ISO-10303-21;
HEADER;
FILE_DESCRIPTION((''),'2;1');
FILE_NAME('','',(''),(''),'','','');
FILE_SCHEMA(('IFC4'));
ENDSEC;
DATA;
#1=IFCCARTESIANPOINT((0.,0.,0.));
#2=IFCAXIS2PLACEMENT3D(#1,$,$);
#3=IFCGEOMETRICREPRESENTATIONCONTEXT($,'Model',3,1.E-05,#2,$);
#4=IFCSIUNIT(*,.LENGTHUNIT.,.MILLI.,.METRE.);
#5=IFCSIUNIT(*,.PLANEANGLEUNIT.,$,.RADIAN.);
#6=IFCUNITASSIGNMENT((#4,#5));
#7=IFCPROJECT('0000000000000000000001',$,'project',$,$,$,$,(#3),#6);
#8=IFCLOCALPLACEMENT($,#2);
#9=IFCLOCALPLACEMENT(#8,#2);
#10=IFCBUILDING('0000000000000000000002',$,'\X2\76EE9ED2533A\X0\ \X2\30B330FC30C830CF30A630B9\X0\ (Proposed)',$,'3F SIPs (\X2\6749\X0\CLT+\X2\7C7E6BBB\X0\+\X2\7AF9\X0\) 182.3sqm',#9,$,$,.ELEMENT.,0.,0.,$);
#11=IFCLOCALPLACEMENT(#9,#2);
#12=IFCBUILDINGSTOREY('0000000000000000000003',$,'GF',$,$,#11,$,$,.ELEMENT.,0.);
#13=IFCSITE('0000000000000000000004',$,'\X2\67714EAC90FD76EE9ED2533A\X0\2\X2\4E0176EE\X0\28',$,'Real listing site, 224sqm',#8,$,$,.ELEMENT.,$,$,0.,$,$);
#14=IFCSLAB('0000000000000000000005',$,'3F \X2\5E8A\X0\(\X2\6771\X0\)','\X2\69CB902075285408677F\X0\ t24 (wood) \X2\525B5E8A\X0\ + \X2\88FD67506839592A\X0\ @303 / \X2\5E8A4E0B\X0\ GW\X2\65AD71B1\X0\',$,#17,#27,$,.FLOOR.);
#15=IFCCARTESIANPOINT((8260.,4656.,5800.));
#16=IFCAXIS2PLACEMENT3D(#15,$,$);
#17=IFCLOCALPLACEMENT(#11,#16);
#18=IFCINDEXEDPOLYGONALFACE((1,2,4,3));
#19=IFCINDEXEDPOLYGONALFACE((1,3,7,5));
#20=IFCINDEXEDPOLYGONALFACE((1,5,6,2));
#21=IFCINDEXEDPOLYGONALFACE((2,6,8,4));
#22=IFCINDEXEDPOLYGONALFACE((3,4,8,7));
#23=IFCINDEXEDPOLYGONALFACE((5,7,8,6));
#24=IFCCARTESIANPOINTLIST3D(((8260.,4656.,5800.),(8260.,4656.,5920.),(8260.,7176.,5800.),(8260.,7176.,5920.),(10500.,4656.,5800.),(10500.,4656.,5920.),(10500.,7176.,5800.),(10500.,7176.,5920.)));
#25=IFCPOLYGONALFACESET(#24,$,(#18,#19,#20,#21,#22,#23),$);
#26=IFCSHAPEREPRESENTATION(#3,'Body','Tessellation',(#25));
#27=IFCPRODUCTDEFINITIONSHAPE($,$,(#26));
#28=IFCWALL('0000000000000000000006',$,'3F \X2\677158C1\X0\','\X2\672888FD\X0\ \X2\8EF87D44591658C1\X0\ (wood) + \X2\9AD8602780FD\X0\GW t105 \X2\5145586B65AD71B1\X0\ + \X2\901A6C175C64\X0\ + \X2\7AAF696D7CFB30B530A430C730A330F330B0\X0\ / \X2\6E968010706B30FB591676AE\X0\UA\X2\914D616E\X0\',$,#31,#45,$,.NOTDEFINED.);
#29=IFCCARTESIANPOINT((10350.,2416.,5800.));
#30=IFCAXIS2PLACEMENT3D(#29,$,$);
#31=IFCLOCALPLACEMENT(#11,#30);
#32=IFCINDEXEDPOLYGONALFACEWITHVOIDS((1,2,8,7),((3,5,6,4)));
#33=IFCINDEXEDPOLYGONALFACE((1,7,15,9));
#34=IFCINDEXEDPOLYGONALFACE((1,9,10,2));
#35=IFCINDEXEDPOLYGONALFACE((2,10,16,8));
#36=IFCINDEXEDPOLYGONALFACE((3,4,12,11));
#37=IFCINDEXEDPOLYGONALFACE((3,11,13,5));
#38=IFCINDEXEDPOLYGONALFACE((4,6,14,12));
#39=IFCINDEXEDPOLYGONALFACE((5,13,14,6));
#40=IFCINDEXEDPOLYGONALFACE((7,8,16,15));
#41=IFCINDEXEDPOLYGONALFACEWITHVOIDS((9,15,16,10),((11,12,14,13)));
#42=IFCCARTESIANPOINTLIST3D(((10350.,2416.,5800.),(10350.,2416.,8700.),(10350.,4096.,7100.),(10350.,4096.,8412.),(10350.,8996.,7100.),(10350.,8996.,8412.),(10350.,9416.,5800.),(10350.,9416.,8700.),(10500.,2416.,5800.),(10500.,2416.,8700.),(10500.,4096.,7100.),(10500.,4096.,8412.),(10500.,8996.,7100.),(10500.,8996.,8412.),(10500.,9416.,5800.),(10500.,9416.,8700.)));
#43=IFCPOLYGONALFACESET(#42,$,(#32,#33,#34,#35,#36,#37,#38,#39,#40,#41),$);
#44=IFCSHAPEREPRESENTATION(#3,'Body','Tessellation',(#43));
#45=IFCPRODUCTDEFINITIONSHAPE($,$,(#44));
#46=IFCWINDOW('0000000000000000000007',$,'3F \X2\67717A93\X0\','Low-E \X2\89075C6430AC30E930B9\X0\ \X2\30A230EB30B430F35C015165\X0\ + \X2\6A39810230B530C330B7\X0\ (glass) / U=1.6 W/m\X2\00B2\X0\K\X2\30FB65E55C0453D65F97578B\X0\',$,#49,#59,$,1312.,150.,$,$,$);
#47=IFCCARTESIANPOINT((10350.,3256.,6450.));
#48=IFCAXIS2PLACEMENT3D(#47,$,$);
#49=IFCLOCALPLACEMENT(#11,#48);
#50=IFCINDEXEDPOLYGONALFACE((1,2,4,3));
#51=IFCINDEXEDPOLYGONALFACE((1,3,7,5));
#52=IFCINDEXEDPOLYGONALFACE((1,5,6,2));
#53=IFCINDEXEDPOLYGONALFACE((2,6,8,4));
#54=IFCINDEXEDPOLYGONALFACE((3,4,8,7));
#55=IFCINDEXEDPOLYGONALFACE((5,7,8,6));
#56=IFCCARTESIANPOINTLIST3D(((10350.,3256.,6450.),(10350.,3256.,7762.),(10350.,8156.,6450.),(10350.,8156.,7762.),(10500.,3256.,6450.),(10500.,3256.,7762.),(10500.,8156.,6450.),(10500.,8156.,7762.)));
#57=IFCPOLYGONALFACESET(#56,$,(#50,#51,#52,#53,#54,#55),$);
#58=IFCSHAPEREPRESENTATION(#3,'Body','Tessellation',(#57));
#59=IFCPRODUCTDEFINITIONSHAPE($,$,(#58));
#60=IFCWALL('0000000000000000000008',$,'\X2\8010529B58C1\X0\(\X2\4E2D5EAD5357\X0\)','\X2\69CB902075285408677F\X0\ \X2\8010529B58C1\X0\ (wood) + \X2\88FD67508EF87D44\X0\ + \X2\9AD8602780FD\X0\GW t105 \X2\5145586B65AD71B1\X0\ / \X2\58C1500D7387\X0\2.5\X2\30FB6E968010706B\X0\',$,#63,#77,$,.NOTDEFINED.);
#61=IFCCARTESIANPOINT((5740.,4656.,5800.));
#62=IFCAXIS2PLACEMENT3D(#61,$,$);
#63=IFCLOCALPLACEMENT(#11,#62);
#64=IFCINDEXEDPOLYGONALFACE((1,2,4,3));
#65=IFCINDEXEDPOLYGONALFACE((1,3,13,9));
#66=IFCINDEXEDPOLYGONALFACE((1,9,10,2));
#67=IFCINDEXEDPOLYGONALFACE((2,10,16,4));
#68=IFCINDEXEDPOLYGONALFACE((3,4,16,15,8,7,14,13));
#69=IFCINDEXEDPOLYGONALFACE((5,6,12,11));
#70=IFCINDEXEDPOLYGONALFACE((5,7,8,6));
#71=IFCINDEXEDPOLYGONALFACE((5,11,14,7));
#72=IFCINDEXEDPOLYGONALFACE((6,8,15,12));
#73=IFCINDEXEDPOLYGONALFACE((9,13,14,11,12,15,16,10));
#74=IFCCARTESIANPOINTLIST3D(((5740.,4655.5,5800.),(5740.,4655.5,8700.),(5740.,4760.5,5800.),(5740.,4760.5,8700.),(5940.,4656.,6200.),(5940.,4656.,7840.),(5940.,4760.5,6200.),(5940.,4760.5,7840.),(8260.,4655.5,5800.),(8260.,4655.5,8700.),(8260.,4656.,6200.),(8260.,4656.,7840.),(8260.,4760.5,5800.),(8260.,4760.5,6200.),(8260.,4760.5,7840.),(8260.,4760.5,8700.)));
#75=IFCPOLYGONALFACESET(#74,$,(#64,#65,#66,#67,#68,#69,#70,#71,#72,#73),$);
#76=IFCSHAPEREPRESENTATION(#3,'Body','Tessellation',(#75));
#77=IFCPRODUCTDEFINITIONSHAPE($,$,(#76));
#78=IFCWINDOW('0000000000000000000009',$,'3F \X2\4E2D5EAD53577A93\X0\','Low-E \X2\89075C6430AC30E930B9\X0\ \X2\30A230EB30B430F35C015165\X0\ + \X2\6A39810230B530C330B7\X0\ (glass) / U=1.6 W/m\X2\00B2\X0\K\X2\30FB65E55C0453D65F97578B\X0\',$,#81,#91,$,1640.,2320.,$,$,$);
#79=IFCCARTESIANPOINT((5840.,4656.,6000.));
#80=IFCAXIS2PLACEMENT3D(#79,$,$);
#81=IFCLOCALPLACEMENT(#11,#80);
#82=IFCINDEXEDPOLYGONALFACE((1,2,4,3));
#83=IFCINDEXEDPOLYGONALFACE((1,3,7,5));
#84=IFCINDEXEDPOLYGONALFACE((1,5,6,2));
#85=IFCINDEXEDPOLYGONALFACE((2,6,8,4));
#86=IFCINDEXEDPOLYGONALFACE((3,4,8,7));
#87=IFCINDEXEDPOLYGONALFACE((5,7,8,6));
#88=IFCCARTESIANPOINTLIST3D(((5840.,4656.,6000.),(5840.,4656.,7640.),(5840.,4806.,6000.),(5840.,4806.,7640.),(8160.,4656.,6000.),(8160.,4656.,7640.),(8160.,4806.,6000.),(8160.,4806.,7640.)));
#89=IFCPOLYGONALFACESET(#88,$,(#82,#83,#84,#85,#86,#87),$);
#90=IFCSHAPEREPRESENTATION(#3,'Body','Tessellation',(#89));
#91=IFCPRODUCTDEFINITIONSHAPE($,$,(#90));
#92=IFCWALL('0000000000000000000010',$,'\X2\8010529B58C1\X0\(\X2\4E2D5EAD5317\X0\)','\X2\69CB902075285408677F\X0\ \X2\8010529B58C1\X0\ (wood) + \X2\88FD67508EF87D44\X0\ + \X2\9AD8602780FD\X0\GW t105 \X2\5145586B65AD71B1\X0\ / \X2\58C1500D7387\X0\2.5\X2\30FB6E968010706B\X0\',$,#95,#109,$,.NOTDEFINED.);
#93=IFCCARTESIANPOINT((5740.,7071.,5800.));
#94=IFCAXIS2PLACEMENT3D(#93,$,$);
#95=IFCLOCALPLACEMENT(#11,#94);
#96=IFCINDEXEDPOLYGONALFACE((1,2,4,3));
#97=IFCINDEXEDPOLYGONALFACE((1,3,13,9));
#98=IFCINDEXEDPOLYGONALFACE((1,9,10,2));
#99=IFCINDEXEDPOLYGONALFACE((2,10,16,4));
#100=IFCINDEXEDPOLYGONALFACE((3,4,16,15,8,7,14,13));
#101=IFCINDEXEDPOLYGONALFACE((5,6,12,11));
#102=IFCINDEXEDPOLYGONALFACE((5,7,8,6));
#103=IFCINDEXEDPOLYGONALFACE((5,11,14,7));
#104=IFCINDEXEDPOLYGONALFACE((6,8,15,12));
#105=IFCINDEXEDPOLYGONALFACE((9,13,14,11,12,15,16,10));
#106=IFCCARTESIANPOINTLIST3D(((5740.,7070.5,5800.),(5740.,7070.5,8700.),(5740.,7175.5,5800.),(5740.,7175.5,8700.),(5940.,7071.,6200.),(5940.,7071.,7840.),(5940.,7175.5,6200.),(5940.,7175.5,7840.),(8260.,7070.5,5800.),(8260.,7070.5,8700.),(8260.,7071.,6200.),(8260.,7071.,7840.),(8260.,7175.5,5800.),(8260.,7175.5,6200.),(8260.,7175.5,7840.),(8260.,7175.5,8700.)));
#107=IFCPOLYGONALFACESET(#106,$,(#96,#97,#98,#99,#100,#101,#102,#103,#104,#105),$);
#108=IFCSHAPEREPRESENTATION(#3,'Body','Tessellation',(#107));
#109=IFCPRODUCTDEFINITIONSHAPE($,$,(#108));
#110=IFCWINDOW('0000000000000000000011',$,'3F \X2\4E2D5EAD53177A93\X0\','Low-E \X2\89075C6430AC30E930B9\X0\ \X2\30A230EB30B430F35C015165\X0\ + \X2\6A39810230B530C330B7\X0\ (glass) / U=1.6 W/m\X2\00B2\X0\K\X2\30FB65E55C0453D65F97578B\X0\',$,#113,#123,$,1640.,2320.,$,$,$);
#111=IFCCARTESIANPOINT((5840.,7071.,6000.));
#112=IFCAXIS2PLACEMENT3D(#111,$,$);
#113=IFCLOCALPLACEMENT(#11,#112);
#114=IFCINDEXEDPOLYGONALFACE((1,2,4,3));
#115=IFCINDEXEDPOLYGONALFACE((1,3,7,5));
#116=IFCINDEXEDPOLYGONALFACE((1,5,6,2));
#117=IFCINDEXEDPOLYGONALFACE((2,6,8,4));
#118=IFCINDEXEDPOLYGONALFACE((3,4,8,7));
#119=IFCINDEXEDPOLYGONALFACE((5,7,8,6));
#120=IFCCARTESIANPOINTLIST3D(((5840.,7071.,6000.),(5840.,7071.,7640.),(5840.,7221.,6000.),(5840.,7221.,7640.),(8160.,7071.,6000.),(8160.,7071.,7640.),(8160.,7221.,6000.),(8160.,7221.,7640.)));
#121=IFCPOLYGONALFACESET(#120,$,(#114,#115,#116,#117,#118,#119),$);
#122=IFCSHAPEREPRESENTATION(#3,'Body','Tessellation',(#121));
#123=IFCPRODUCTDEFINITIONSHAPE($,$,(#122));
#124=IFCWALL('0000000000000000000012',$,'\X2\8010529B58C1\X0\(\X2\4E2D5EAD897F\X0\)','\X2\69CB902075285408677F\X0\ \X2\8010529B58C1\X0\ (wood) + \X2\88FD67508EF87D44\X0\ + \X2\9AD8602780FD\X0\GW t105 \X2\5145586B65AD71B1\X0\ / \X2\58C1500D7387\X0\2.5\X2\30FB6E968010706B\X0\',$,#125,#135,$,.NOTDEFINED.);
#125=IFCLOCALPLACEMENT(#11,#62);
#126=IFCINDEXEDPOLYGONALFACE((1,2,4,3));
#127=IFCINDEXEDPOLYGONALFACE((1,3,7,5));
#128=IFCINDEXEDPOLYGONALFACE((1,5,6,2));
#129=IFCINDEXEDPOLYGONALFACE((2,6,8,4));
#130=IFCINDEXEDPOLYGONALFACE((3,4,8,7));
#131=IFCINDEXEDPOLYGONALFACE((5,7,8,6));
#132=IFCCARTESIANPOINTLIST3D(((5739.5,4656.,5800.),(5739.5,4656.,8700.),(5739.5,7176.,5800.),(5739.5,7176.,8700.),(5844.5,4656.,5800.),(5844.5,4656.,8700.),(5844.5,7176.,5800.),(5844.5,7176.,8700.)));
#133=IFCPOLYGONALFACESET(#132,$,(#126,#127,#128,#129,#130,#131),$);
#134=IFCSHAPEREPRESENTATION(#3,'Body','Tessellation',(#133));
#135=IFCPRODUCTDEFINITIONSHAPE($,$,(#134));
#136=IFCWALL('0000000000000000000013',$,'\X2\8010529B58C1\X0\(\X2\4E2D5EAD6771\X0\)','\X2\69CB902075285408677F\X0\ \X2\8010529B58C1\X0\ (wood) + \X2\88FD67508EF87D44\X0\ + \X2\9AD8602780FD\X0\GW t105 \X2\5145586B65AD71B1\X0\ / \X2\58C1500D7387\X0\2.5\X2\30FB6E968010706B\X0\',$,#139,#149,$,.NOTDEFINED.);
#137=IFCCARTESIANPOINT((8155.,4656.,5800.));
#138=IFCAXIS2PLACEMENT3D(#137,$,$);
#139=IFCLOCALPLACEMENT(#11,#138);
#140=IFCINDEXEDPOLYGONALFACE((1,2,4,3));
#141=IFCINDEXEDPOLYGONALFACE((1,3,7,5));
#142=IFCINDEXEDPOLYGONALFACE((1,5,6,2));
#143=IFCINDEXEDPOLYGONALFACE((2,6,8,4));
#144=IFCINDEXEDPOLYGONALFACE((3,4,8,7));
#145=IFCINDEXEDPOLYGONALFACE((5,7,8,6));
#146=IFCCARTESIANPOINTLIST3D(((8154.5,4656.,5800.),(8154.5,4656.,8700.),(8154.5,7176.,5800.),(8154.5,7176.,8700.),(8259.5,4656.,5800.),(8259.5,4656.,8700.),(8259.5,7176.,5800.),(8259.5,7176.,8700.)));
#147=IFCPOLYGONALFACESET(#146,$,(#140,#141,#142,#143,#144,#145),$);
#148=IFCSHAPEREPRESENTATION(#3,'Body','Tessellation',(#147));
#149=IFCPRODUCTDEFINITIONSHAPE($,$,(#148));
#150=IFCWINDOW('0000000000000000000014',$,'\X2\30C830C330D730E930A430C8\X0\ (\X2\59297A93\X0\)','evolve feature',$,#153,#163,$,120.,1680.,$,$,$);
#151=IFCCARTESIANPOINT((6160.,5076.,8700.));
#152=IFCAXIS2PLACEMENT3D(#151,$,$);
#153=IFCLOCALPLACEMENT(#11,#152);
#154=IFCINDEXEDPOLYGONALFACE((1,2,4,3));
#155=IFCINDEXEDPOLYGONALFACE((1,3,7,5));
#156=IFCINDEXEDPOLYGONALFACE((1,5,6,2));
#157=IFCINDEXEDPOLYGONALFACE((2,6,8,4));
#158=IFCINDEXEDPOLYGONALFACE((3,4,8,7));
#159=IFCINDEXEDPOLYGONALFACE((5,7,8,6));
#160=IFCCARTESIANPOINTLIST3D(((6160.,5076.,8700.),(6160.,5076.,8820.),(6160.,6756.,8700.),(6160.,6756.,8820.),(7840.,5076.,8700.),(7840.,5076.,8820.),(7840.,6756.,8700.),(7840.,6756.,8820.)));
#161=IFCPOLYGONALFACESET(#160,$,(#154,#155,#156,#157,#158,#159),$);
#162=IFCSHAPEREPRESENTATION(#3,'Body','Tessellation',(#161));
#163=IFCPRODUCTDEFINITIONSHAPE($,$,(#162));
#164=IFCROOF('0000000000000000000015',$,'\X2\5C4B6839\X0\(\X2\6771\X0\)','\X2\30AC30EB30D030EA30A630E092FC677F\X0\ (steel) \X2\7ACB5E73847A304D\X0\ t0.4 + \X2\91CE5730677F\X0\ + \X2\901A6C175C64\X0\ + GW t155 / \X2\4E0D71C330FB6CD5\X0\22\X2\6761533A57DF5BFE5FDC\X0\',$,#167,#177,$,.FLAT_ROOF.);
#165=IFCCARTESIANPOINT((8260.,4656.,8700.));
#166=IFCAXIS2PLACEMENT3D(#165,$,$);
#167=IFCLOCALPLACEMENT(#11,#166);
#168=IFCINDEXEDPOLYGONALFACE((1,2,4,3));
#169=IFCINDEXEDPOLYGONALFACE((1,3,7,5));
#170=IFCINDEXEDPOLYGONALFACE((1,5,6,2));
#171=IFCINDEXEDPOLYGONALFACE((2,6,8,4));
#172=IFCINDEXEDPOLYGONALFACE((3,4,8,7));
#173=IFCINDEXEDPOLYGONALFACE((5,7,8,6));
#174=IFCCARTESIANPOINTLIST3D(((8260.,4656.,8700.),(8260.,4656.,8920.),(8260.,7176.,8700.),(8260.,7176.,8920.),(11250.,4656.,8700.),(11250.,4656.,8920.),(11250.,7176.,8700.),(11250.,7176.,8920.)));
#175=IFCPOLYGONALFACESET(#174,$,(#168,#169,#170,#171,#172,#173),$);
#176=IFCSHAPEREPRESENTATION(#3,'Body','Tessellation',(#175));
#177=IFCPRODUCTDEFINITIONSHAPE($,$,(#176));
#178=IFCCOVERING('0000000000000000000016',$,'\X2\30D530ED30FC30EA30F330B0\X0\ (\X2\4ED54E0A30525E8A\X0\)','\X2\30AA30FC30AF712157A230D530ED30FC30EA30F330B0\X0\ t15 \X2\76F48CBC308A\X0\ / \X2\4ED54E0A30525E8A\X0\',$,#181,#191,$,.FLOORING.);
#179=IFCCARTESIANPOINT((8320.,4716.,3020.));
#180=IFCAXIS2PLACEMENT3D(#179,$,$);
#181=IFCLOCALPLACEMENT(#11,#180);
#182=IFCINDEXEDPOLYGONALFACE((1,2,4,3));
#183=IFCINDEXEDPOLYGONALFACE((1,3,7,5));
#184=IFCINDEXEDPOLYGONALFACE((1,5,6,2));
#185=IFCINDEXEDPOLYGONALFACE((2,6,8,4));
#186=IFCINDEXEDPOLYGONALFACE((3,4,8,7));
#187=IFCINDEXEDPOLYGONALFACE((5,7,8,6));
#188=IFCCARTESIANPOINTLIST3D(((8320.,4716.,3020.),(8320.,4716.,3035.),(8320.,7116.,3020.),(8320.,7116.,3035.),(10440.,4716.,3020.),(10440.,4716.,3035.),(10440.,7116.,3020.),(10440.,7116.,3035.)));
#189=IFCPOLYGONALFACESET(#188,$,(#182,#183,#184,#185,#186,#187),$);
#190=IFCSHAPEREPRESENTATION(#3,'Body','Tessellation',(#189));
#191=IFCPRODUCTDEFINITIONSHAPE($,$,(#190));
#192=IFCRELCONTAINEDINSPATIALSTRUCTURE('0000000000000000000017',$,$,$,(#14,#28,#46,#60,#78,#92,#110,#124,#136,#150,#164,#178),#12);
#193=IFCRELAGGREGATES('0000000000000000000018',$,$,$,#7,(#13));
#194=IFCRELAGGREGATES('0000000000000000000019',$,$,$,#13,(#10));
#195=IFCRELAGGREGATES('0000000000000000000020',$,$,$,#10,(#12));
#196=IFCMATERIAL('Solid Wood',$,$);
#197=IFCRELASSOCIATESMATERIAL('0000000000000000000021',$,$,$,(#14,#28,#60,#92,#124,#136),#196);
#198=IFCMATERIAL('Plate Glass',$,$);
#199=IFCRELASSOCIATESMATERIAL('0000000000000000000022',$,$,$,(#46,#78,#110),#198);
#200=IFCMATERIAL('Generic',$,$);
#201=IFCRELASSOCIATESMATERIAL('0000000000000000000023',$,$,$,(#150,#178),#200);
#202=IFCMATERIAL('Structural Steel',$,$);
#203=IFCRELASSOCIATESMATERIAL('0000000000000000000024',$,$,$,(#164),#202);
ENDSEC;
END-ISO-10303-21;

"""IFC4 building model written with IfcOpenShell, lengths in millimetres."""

from ifc_helpers import new_model, si_unit, frame, frame_2d, origin, place, context, project, spatial, rectangle, extrude, material, element, fill, save


model = new_model("IFC4")

# Units and contexts
model_context = context("Model", 3, precision=1e-05, world=origin())
ifc_project = project(units=[si_unit("LENGTHUNIT", "METRE", prefix="MILLI"), si_unit("PLANEANGLEUNIT", "RADIAN")], contexts=[model_context])

# Site, building, storey
site_placement = place(None, origin())
site = spatial("IfcSite", under=ifc_project, at=site_placement, Name="東京都目黒区2丁目28", ObjectType="Real listing site, 224sqm", CompositionType="ELEMENT", RefElevation=0.0)
building_placement = place(site_placement, origin())
building = spatial("IfcBuilding", under=site, at=building_placement, Name="目黒区 コートハウス (Proposed)", ObjectType="3F SIPs (杉CLT+籾殻+竹) 182.3sqm", CompositionType="ELEMENT", ElevationOfRefHeight=0.0, ElevationOfTerrain=0.0)
storey_placement = place(building_placement, origin())
storey = spatial("IfcBuildingStorey", under=building, at=storey_placement, Name="GF", CompositionType="ELEMENT", Elevation=0.0)

# Slab
ifc_material_1 = material(Name="Solid Wood")
slab_placement = place(storey_placement, frame((8260.0, 4656.0, 5800.0)))
element("IfcSlab", 1, at=slab_placement, inside=storey, material=ifc_material_1, Name="3F 床(東)", Description="構造用合板 t24 (wood) 剛床 + 製材根太 @303 / 床下 GW断熱", PredefinedType="FLOOR", context=model_context, shape_type="SweptSolid", body=[
    extrude(rectangle(XDim=2240.0, YDim=2520.0, at=frame_2d((1120.0, 1260.0))), frame((8260.0, 4656.0, 5800.0)), (0.0, 0.0, 1.0), 120.0),
])

# Walls, openings, windows
wall_1_placement = place(storey_placement, frame((10350.0, 2416.0, 5800.0)))
wall_1 = element("IfcWall", 2, at=wall_1_placement, inside=storey, material=ifc_material_1, Name="3F 東壁", Description="木製 軸組外壁 (wood) + 高性能GW t105 充填断熱 + 通気層 + 窯業系サイディング / 準耐火・外皮UA配慮", PredefinedType="NOTDEFINED", context=model_context, shape_type="SweptSolid", body=[
    extrude(rectangle(XDim=150.0, YDim=7000.0, at=frame_2d((75.0, 3500.0))), frame((10350.0, 2416.0, 5800.0)), (0.0, 0.0, 1.0), 2900.0),
])
opening_1_placement = place(storey_placement, frame((10350.0, 3256.0, 6450.0)))
opening_1 = element("IfcOpeningElement", 3, at=opening_1_placement, cuts=wall_1, PredefinedType="NOTDEFINED", context=model_context, shape_type="SweptSolid", body=[
    extrude(rectangle(XDim=150.0, YDim=4900.0, at=frame_2d((75.0, 2450.0))), frame((10350.0, 3256.0, 6450.0)), (0.0, 0.0, 1.0), 1312.0),
])
ifc_material_2 = material(Name="Plate Glass")
window_1_placement = place(storey_placement, frame((10350.0, 3256.0, 6450.0)))
window_1 = element("IfcWindow", 4, at=window_1_placement, inside=storey, material=ifc_material_2, Name="3F 東窓", Description="Low-E 複層ガラス アルゴン封入 + 樹脂サッシ (glass) / U=1.6 W/m²K・日射取得型", OverallHeight=1312.0, OverallWidth=150.0, context=model_context, shape_type="SweptSolid", body=[
    extrude(rectangle(XDim=150.0, YDim=4900.0, at=frame_2d((75.0, 2450.0))), frame((10350.0, 3256.0, 6450.0)), (0.0, 0.0, 1.0), 1312.0),
])
fill(opening_1, window_1)
wall_2_placement = place(storey_placement, frame((5740.0, 4656.0, 5800.0)))
wall_2 = element("IfcWall", 5, at=wall_2_placement, inside=storey, material=ifc_material_1, Name="耐力壁(中庭南)", Description="構造用合板 耐力壁 (wood) + 製材軸組 + 高性能GW t105 充填断熱 / 壁倍率2.5・準耐火", PredefinedType="NOTDEFINED", context=model_context, shape_type="SweptSolid", body=[
    extrude(rectangle(XDim=2520.0, YDim=105.0, at=frame_2d((1260.0, 52.0))), frame((5740.0, 4656.0, 5800.0)), (0.0, 0.0, 1.0), 2900.0),
])
opening_2_placement = place(storey_placement, frame((5840.0, 4656.0, 6000.0)))
opening_2 = element("IfcOpeningElement", 6, at=opening_2_placement, cuts=wall_2, PredefinedType="NOTDEFINED", context=model_context, shape_type="SweptSolid", body=[
    extrude(rectangle(XDim=2320.0, YDim=150.0, at=frame_2d((1160.0, 75.0))), frame((5840.0, 4656.0, 6000.0)), (0.0, 0.0, 1.0), 1640.0),
])
window_2_placement = place(storey_placement, frame((5840.0, 4656.0, 6000.0)))
window_2 = element("IfcWindow", 7, at=window_2_placement, inside=storey, material=ifc_material_2, Name="3F 中庭南窓", Description="Low-E 複層ガラス アルゴン封入 + 樹脂サッシ (glass) / U=1.6 W/m²K・日射取得型", OverallHeight=1640.0, OverallWidth=2320.0, context=model_context, shape_type="SweptSolid", body=[
    extrude(rectangle(XDim=2320.0, YDim=150.0, at=frame_2d((1160.0, 75.0))), frame((5840.0, 4656.0, 6000.0)), (0.0, 0.0, 1.0), 1640.0),
])
fill(opening_2, window_2)
wall_3_placement = place(storey_placement, frame((5740.0, 7071.0, 5800.0)))
wall_3 = element("IfcWall", 8, at=wall_3_placement, inside=storey, material=ifc_material_1, Name="耐力壁(中庭北)", Description="構造用合板 耐力壁 (wood) + 製材軸組 + 高性能GW t105 充填断熱 / 壁倍率2.5・準耐火", PredefinedType="NOTDEFINED", context=model_context, shape_type="SweptSolid", body=[
    extrude(rectangle(XDim=2520.0, YDim=105.0, at=frame_2d((1260.0, 52.0))), frame((5740.0, 7071.0, 5800.0)), (0.0, 0.0, 1.0), 2900.0),
])
opening_3_placement = place(storey_placement, frame((5840.0, 7071.0, 6000.0)))
opening_3 = element("IfcOpeningElement", 9, at=opening_3_placement, cuts=wall_3, PredefinedType="NOTDEFINED", context=model_context, shape_type="SweptSolid", body=[
    extrude(rectangle(XDim=2320.0, YDim=150.0, at=frame_2d((1160.0, 75.0))), frame((5840.0, 7071.0, 6000.0)), (0.0, 0.0, 1.0), 1640.0),
])
window_3_placement = place(storey_placement, frame((5840.0, 7071.0, 6000.0)))
window_3 = element("IfcWindow", 10, at=window_3_placement, inside=storey, material=ifc_material_2, Name="3F 中庭北窓", Description="Low-E 複層ガラス アルゴン封入 + 樹脂サッシ (glass) / U=1.6 W/m²K・日射取得型", OverallHeight=1640.0, OverallWidth=2320.0, context=model_context, shape_type="SweptSolid", body=[
    extrude(rectangle(XDim=2320.0, YDim=150.0, at=frame_2d((1160.0, 75.0))), frame((5840.0, 7071.0, 6000.0)), (0.0, 0.0, 1.0), 1640.0),
])
fill(opening_3, window_3)

# Walls
wall_4_placement = place(storey_placement, frame((5740.0, 4656.0, 5800.0)))
element("IfcWall", 11, at=wall_4_placement, inside=storey, material=ifc_material_1, Name="耐力壁(中庭西)", Description="構造用合板 耐力壁 (wood) + 製材軸組 + 高性能GW t105 充填断熱 / 壁倍率2.5・準耐火", PredefinedType="NOTDEFINED", context=model_context, shape_type="SweptSolid", body=[
    extrude(rectangle(XDim=105.0, YDim=2520.0, at=frame_2d((52.0, 1260.0))), frame((5740.0, 4656.0, 5800.0)), (0.0, 0.0, 1.0), 2900.0),
])
wall_5_placement = place(storey_placement, frame((8155.0, 4656.0, 5800.0)))
element("IfcWall", 12, at=wall_5_placement, inside=storey, material=ifc_material_1, Name="耐力壁(中庭東)", Description="構造用合板 耐力壁 (wood) + 製材軸組 + 高性能GW t105 充填断熱 / 壁倍率2.5・準耐火", PredefinedType="NOTDEFINED", context=model_context, shape_type="SweptSolid", body=[
    extrude(rectangle(XDim=105.0, YDim=2520.0, at=frame_2d((52.0, 1260.0))), frame((8155.0, 4656.0, 5800.0)), (0.0, 0.0, 1.0), 2900.0),
])

# Window
ifc_material_3 = material(Name="Generic")
window_4_placement = place(storey_placement, frame((6160.0, 5076.0, 8700.0)))
element("IfcWindow", 13, at=window_4_placement, inside=storey, material=ifc_material_3, Name="トップライト (天窓)", Description="evolve feature", OverallHeight=120.0, OverallWidth=1680.0, context=model_context, shape_type="SweptSolid", body=[
    extrude(rectangle(XDim=1680.0, YDim=1680.0, at=frame_2d((840.0, 840.0))), frame((6160.0, 5076.0, 8700.0)), (0.0, 0.0, 1.0), 120.0),
])

# Roof
ifc_material_4 = material(Name="Structural Steel")
for number, where, name in (
    (14, (8260.0, 4656.0, 8700.0), "屋根(東)"),
):
    element("IfcRoof", number, at=place(storey_placement, frame(where)), inside=storey, material=ifc_material_4, Name=name, Description="ガルバリウム鋼板 (steel) 立平葺き t0.4 + 野地板 + 通気層 + GW t155 / 不燃・法22条区域対応", PredefinedType="FLAT_ROOF", context=model_context, shape_type="SweptSolid", body=[
        extrude(rectangle(XDim=2990.0, YDim=2520.0, at=frame_2d((1495.0, 1260.0))), frame((8260.0, 4656.0, 8700.0)), (0.0, 0.0, 1.0), 220.0),
    ])

# Covering
covering_1_placement = place(storey_placement, frame((8320.0, 4716.0, 3020.0)))
element("IfcCovering", 15, at=covering_1_placement, inside=storey, material=ifc_material_3, Name="フローリング (仕上げ床)", Description="オーク無垢フローリング t15 直貼り / 仕上げ床", PredefinedType="FLOORING", context=model_context, shape_type="SweptSolid", body=[
    extrude(rectangle(XDim=2120.0, YDim=2400.0, at=frame_2d((1060.0, 1200.0))), frame((8320.0, 4716.0, 3020.0)), (0.0, 0.0, 1.0), 15.0),
])

save(model, "model.ifc")
